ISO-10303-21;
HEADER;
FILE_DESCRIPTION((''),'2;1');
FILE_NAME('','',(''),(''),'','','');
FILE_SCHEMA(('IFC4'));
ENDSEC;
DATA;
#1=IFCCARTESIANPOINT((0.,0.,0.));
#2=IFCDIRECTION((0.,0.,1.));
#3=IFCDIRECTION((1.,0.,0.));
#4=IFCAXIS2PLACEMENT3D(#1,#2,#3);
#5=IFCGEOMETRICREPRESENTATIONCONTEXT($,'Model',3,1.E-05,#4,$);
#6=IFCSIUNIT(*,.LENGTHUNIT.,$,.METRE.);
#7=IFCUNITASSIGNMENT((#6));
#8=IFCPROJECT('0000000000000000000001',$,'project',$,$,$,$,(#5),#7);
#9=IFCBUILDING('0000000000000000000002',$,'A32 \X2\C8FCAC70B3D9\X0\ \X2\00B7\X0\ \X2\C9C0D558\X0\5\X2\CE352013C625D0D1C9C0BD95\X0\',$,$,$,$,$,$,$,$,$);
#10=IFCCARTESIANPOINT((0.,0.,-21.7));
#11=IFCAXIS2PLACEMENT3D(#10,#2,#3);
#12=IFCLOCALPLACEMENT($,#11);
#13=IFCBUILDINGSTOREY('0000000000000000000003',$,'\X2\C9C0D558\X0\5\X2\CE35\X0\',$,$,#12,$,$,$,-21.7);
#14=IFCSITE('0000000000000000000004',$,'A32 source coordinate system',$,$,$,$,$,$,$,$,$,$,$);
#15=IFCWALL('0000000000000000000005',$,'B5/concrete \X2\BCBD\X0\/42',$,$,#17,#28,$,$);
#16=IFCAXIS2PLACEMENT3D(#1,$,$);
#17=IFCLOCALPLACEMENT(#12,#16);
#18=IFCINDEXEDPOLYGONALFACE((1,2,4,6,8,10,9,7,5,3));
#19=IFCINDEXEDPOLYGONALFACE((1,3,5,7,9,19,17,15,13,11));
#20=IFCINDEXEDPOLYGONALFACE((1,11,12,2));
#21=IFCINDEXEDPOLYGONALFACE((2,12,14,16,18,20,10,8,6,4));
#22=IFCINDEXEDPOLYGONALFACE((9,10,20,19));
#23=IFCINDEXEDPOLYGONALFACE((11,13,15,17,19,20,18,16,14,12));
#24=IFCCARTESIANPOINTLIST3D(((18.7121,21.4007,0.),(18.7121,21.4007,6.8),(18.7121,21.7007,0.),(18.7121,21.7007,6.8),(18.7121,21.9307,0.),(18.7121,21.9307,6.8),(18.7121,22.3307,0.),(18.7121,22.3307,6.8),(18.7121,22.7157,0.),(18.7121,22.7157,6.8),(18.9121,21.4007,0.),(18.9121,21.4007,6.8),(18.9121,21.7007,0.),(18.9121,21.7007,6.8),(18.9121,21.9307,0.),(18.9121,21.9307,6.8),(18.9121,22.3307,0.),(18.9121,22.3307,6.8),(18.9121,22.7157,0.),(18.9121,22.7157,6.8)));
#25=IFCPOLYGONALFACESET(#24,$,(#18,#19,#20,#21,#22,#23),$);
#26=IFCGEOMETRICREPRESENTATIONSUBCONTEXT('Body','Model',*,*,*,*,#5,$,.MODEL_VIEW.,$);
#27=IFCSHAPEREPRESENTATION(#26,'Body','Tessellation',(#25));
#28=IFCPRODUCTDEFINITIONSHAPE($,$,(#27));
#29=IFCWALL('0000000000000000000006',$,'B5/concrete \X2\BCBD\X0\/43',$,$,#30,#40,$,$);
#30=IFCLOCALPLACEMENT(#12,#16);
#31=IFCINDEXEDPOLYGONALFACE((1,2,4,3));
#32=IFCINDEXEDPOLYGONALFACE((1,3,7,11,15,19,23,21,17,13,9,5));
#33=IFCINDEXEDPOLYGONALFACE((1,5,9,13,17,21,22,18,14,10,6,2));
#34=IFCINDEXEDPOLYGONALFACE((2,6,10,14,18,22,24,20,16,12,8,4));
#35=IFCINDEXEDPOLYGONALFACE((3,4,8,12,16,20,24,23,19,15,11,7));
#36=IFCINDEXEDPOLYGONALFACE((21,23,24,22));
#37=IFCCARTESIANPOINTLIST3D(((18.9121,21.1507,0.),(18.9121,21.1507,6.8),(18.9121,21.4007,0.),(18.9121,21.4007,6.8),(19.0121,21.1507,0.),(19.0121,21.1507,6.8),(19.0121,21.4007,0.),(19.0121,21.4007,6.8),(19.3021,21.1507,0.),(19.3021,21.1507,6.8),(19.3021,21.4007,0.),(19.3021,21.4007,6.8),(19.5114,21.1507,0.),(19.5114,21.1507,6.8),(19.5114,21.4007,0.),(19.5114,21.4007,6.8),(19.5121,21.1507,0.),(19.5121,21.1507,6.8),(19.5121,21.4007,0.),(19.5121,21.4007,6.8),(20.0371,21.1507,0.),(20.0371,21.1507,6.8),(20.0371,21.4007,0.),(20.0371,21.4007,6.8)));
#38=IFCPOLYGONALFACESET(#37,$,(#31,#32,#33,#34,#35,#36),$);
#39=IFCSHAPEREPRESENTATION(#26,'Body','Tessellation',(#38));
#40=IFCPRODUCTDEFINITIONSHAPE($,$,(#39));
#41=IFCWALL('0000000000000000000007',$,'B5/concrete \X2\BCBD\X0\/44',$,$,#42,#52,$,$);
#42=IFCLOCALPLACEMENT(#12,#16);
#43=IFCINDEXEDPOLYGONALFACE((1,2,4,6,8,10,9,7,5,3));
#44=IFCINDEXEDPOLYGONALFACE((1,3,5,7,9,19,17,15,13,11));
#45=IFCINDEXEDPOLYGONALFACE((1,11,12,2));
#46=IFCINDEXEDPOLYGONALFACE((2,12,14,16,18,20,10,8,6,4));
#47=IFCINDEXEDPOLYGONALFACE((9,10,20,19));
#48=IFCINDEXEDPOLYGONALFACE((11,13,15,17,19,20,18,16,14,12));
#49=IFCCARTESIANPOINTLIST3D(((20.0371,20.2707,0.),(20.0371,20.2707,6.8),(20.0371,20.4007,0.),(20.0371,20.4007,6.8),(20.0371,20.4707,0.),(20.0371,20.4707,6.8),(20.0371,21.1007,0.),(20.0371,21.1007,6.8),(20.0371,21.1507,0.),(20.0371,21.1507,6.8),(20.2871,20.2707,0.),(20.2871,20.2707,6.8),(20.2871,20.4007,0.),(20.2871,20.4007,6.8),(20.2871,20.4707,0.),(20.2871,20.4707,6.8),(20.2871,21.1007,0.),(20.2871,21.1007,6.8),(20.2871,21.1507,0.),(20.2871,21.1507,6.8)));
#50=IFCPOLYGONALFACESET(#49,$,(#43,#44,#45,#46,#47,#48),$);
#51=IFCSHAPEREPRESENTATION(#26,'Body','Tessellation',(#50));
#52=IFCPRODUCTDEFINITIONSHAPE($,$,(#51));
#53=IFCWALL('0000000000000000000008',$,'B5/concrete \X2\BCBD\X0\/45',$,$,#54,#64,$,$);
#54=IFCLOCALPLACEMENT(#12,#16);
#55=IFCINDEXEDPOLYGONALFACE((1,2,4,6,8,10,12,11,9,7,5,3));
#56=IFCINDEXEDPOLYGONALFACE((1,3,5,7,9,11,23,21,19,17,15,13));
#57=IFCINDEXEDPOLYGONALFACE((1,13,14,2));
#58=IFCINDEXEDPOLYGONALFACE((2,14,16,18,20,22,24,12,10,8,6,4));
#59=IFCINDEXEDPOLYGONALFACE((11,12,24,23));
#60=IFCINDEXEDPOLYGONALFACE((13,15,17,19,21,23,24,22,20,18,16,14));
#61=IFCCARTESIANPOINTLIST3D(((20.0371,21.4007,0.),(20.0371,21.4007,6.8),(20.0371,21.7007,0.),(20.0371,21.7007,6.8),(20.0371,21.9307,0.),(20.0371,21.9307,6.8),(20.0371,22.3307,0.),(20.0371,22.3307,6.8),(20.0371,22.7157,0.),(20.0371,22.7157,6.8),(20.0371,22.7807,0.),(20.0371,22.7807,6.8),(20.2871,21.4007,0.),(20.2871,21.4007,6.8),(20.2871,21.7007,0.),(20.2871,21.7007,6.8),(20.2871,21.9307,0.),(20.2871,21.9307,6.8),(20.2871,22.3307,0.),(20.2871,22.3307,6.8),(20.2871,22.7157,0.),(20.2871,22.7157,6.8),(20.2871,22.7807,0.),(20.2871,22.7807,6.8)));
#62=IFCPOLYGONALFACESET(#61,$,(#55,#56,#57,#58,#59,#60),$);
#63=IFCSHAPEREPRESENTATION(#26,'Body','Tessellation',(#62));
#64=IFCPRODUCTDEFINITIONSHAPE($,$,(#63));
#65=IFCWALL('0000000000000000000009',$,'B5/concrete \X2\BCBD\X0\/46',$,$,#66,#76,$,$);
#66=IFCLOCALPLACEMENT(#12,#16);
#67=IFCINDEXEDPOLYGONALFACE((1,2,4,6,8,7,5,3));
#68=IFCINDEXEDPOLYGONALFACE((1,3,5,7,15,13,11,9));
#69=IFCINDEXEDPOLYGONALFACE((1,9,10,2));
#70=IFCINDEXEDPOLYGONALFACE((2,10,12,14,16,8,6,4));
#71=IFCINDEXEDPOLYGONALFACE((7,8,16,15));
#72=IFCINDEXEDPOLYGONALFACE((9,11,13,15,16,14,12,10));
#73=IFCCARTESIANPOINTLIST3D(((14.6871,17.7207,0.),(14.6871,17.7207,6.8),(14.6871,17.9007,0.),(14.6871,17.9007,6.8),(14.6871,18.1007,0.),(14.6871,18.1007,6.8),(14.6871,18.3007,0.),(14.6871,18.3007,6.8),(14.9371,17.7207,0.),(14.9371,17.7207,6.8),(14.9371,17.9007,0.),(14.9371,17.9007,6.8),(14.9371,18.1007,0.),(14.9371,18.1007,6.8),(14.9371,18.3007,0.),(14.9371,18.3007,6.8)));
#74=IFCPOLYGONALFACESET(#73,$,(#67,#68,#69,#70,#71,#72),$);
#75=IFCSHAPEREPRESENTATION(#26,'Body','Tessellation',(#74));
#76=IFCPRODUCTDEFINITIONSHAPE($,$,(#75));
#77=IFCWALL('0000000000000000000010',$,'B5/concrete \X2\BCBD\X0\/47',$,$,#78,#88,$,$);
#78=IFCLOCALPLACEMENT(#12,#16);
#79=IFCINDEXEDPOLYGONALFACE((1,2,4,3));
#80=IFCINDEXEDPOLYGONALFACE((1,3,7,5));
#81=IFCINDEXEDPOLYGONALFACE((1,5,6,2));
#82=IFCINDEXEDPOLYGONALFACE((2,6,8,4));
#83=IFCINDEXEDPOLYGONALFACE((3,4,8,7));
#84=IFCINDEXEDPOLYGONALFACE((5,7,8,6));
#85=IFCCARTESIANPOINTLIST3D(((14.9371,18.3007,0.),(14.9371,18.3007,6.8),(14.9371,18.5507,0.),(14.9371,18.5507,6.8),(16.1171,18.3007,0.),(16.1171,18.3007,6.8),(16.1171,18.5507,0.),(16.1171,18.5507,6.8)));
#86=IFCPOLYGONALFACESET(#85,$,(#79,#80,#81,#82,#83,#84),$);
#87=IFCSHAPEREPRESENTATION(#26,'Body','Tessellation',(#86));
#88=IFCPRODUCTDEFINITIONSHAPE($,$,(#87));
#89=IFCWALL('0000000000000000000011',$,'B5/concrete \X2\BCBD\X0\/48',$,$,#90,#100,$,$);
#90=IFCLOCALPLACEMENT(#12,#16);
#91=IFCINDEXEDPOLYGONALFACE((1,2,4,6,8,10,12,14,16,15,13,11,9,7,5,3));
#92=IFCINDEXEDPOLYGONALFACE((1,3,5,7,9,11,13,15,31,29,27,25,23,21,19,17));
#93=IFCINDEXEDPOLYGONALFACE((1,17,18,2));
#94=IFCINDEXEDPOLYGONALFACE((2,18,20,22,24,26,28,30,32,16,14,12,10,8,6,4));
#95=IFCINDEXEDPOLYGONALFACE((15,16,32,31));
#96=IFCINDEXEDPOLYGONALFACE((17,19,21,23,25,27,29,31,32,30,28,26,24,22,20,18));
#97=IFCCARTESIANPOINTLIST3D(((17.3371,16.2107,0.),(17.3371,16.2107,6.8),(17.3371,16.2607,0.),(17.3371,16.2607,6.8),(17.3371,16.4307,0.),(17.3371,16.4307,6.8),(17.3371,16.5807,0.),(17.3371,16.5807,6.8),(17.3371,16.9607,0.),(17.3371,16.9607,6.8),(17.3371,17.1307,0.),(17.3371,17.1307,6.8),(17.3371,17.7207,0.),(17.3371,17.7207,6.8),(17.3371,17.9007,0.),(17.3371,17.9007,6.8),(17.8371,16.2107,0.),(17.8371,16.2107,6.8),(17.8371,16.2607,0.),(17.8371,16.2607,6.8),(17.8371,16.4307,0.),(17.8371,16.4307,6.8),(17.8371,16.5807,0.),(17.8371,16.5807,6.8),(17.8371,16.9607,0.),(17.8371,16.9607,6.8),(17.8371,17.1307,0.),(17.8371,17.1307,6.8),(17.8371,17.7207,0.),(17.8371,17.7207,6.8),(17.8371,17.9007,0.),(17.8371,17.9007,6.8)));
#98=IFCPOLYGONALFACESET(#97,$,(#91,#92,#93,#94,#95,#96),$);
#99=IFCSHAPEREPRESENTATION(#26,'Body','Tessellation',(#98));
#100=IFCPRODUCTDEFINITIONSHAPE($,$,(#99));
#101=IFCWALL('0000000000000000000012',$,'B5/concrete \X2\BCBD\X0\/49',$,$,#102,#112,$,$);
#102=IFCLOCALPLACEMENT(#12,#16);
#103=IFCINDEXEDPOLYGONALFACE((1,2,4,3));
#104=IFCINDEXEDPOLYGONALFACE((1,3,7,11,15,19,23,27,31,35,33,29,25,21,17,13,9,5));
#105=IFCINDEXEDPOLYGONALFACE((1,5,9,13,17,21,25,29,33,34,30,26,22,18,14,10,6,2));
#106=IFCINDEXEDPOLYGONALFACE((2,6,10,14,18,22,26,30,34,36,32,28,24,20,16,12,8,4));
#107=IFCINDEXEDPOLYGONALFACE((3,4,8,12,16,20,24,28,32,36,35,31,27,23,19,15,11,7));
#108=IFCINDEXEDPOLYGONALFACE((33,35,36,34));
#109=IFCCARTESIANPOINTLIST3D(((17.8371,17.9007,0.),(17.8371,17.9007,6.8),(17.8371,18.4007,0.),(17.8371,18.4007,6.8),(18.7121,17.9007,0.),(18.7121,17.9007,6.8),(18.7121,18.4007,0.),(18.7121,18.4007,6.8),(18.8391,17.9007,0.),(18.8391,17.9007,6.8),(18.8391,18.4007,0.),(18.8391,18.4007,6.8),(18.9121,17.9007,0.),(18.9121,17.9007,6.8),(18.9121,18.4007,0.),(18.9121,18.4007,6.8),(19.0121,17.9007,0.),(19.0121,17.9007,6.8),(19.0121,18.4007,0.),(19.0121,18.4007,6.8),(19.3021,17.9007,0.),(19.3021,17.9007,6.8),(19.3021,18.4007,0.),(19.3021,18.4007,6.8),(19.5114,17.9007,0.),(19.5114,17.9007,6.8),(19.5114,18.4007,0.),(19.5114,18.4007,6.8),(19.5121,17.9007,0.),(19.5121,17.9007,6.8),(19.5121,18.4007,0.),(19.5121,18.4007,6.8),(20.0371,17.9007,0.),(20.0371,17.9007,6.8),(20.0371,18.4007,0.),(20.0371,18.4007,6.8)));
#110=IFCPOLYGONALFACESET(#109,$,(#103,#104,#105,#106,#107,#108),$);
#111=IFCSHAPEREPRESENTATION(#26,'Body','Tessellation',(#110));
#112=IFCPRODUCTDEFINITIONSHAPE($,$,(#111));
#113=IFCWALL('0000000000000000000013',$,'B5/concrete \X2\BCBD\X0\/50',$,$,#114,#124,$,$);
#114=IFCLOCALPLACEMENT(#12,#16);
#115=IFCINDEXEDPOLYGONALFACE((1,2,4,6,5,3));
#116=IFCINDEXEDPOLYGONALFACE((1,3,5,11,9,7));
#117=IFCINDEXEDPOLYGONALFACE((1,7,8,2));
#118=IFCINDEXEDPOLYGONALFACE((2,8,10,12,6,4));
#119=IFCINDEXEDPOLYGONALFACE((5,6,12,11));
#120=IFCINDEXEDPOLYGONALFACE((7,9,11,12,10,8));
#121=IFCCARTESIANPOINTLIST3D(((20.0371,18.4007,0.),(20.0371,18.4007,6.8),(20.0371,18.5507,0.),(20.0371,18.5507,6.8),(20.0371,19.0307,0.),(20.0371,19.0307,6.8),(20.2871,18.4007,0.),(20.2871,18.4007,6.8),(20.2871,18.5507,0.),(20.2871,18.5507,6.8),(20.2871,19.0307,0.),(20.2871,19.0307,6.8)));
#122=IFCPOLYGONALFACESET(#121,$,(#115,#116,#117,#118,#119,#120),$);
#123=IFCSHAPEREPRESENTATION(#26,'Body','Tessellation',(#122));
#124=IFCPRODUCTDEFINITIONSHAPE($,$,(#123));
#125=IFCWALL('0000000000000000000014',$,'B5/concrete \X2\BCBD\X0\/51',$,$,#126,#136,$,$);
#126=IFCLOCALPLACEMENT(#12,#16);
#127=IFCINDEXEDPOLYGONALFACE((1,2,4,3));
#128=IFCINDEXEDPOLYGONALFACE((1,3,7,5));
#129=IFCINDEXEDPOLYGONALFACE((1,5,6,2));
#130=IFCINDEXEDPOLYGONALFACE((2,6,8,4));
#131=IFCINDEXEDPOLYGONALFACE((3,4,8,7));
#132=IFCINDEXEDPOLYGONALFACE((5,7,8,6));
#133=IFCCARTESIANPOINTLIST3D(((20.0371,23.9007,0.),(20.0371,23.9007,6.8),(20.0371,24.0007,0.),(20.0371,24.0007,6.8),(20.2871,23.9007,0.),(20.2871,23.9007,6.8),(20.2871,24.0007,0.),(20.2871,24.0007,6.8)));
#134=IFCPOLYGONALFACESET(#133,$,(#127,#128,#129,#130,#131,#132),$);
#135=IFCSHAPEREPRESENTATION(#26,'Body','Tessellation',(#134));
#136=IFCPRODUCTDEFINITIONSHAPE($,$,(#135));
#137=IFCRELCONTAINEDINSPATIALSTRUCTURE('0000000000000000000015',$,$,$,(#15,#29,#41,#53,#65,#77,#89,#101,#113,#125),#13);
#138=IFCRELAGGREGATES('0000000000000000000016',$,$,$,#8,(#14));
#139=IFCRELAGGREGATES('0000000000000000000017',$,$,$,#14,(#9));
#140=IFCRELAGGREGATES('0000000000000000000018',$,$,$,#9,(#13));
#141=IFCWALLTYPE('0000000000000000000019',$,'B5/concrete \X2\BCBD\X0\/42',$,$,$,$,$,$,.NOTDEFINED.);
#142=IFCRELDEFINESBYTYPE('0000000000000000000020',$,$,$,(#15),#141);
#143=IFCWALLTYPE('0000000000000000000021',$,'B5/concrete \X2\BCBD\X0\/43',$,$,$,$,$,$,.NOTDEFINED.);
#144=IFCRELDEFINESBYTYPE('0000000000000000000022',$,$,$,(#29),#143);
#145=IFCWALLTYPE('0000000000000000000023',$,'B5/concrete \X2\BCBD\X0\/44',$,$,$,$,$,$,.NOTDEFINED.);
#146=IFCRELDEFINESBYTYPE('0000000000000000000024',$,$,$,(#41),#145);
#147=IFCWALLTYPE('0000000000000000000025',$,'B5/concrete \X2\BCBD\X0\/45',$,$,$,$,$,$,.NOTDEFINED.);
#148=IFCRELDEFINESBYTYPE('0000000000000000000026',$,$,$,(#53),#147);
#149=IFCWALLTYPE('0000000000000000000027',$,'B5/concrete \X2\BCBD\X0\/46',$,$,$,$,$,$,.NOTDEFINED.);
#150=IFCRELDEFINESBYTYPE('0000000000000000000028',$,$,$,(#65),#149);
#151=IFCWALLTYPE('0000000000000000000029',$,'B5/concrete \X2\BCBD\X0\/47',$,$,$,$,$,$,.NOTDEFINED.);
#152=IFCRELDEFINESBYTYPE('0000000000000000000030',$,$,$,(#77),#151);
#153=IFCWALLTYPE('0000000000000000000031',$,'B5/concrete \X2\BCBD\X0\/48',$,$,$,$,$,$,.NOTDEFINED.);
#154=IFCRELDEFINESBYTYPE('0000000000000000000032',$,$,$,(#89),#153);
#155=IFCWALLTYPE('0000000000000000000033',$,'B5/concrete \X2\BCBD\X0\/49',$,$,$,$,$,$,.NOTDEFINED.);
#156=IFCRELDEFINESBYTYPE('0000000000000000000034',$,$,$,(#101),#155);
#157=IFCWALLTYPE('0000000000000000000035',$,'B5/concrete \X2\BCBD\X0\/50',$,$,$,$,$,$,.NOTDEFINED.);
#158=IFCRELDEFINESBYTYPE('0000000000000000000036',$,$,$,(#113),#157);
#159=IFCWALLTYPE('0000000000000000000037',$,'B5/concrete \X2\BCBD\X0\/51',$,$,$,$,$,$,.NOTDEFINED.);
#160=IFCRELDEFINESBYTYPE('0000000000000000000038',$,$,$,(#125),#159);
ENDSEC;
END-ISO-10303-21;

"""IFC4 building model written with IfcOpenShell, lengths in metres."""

from ifc_helpers import new_model, si_unit, frame, origin, origin_with_axes, place, context, subcontext, project, spatial, polyline, outline, extrude, source, transform, mapped, type_object, type_shapes, element, save


model = new_model("IFC4")

# Units and contexts
model_context = context("Model", 3, precision=1e-05, world=origin_with_axes())
body_context = subcontext(model_context, "Body", "Model", "MODEL_VIEW")
ifc_project = project(units=[si_unit("LENGTHUNIT", "METRE")], contexts=[model_context])

# Site, building, storey
site = spatial("IfcSite", under=ifc_project, Name="A32 source coordinate system")
building = spatial("IfcBuilding", under=site, Name="A32 주거동 · 지하5층–옥탑지붕")
storey_placement = place(None, frame((0.0, 0.0, -21.7), z_axis=(0.0, 0.0, 1.0), x_axis=(1.0, 0.0, 0.0)))
storey = spatial("IfcBuildingStorey", under=building, at=storey_placement, Name="지하5층", Elevation=-21.7)

# Walls
wall_type_1 = type_object("IfcWallType", Name="B5/concrete 벽/42", PredefinedType="NOTDEFINED")
shared_shape_1 = source(origin(), body_context, "Body", "SweptSolid", [
    extrude(outline(polyline([(18.7121, 22.3307), (18.7121, 22.7157), (18.9121, 22.7157), (18.9121, 22.3307), (18.9121, 21.9307), (18.9121, 21.7007), (18.9121, 21.4007), (18.7121, 21.4007), (18.7121, 21.7007), (18.7121, 21.9307), (18.7121, 22.3307)])), origin(), (0.0, 0.0, 1.0), 6.8),
])
type_shapes(wall_type_1, [shared_shape_1])
wall_1_placement = place(storey_placement, origin_with_axes())
element("IfcWall", 1, at=wall_1_placement, inside=storey, type_object=wall_type_1, Name="B5/concrete 벽/42", context=body_context, shape_type="MappedRepresentation", body=[
    mapped(shared_shape_1, transform((0.0, 0.0, 0.0), scale=1.0)),
])
wall_type_2 = type_object("IfcWallType", Name="B5/concrete 벽/43", PredefinedType="NOTDEFINED")
shared_shape_2 = source(origin(), body_context, "Body", "SweptSolid", [
    extrude(outline(polyline([(19.5114, 21.4007), (19.5121, 21.4007), (20.0371, 21.4007), (20.0371, 21.1507), (19.5121, 21.1507), (19.5114, 21.1507), (19.3021, 21.1507), (19.0121, 21.1507), (18.9121, 21.1507), (18.9121, 21.4007), (19.0121, 21.4007), (19.3021, 21.4007), (19.5114, 21.4007)])), origin(), (0.0, 0.0, 1.0), 6.8),
])
type_shapes(wall_type_2, [shared_shape_2])
wall_2_placement = place(storey_placement, origin_with_axes())
element("IfcWall", 2, at=wall_2_placement, inside=storey, type_object=wall_type_2, Name="B5/concrete 벽/43", context=body_context, shape_type="MappedRepresentation", body=[
    mapped(shared_shape_2, transform((0.0, 0.0, 0.0), scale=1.0)),
])
wall_type_3 = type_object("IfcWallType", Name="B5/concrete 벽/44", PredefinedType="NOTDEFINED")
shared_shape_3 = source(origin(), body_context, "Body", "SweptSolid", [
    extrude(outline(polyline([(20.2871, 20.4707), (20.2871, 20.4007), (20.2871, 20.2707), (20.0371, 20.2707), (20.0371, 20.4007), (20.0371, 20.4707), (20.0371, 21.1007), (20.0371, 21.1507), (20.2871, 21.1507), (20.2871, 21.1007), (20.2871, 20.4707)])), origin(), (0.0, 0.0, 1.0), 6.8),
])
type_shapes(wall_type_3, [shared_shape_3])
wall_3_placement = place(storey_placement, origin_with_axes())
element("IfcWall", 3, at=wall_3_placement, inside=storey, type_object=wall_type_3, Name="B5/concrete 벽/44", context=body_context, shape_type="MappedRepresentation", body=[
    mapped(shared_shape_3, transform((0.0, 0.0, 0.0), scale=1.0)),
])
wall_type_4 = type_object("IfcWallType", Name="B5/concrete 벽/45", PredefinedType="NOTDEFINED")
shared_shape_4 = source(origin(), body_context, "Body", "SweptSolid", [
    extrude(outline(polyline([(20.0371, 22.3307), (20.0371, 22.7157), (20.0371, 22.7807), (20.2871, 22.7807), (20.2871, 22.7157), (20.2871, 22.3307), (20.2871, 21.9307), (20.2871, 21.7007), (20.2871, 21.4007), (20.0371, 21.4007), (20.0371, 21.7007), (20.0371, 21.9307), (20.0371, 22.3307)])), origin(), (0.0, 0.0, 1.0), 6.8),
])
type_shapes(wall_type_4, [shared_shape_4])
wall_4_placement = place(storey_placement, origin_with_axes())
element("IfcWall", 4, at=wall_4_placement, inside=storey, type_object=wall_type_4, Name="B5/concrete 벽/45", context=body_context, shape_type="MappedRepresentation", body=[
    mapped(shared_shape_4, transform((0.0, 0.0, 0.0), scale=1.0)),
])
wall_type_5 = type_object("IfcWallType", Name="B5/concrete 벽/46", PredefinedType="NOTDEFINED")
shared_shape_5 = source(origin(), body_context, "Body", "SweptSolid", [
    extrude(outline(polyline([(14.9371, 17.9007), (14.9371, 17.7207), (14.6871, 17.7207), (14.6871, 17.9007), (14.6871, 18.1007), (14.6871, 18.3007), (14.9371, 18.3007), (14.9371, 18.1007), (14.9371, 17.9007)])), origin(), (0.0, 0.0, 1.0), 6.8),
])
type_shapes(wall_type_5, [shared_shape_5])
wall_5_placement = place(storey_placement, origin_with_axes())
element("IfcWall", 5, at=wall_5_placement, inside=storey, type_object=wall_type_5, Name="B5/concrete 벽/46", context=body_context, shape_type="MappedRepresentation", body=[
    mapped(shared_shape_5, transform((0.0, 0.0, 0.0), scale=1.0)),
])
wall_type_6 = type_object("IfcWallType", Name="B5/concrete 벽/47", PredefinedType="NOTDEFINED")
shared_shape_6 = source(origin(), body_context, "Body", "SweptSolid", [
    extrude(outline(polyline([(16.1171, 18.3007), (14.9371, 18.3007), (14.9371, 18.5507), (16.1171, 18.5507), (16.1171, 18.3007)])), origin(), (0.0, 0.0, 1.0), 6.8),
])
type_shapes(wall_type_6, [shared_shape_6])
wall_6_placement = place(storey_placement, origin_with_axes())
element("IfcWall", 6, at=wall_6_placement, inside=storey, type_object=wall_type_6, Name="B5/concrete 벽/47", context=body_context, shape_type="MappedRepresentation", body=[
    mapped(shared_shape_6, transform((0.0, 0.0, 0.0), scale=1.0)),
])
wall_type_7 = type_object("IfcWallType", Name="B5/concrete 벽/48", PredefinedType="NOTDEFINED")
shared_shape_7 = source(origin(), body_context, "Body", "SweptSolid", [
    extrude(outline(polyline([(17.8371, 17.1307), (17.8371, 16.9607), (17.8371, 16.5807), (17.8371, 16.4307), (17.8371, 16.2607), (17.8371, 16.2107), (17.3371, 16.2107), (17.3371, 16.2607), (17.3371, 16.4307), (17.3371, 16.5807), (17.3371, 16.9607), (17.3371, 17.1307), (17.3371, 17.7207), (17.3371, 17.9007), (17.8371, 17.9007), (17.8371, 17.7207), (17.8371, 17.1307)])), origin(), (0.0, 0.0, 1.0), 6.8),
])
type_shapes(wall_type_7, [shared_shape_7])
wall_7_placement = place(storey_placement, origin_with_axes())
element("IfcWall", 7, at=wall_7_placement, inside=storey, type_object=wall_type_7, Name="B5/concrete 벽/48", context=body_context, shape_type="MappedRepresentation", body=[
    mapped(shared_shape_7, transform((0.0, 0.0, 0.0), scale=1.0)),
])
wall_type_8 = type_object("IfcWallType", Name="B5/concrete 벽/49", PredefinedType="NOTDEFINED")
shared_shape_8 = source(origin(), body_context, "Body", "SweptSolid", [
    extrude(outline(polyline([(18.8391, 18.4007), (18.9121, 18.4007), (19.0121, 18.4007), (19.3021, 18.4007), (19.5114, 18.4007), (19.5121, 18.4007), (20.0371, 18.4007), (20.0371, 17.9007), (19.5121, 17.9007), (19.5114, 17.9007), (19.3021, 17.9007), (19.0121, 17.9007), (18.9121, 17.9007), (18.8391, 17.9007), (18.7121, 17.9007), (17.8371, 17.9007), (17.8371, 18.4007), (18.7121, 18.4007), (18.8391, 18.4007)])), origin(), (0.0, 0.0, 1.0), 6.8),
])
type_shapes(wall_type_8, [shared_shape_8])
wall_8_placement = place(storey_placement, origin_with_axes())
element("IfcWall", 8, at=wall_8_placement, inside=storey, type_object=wall_type_8, Name="B5/concrete 벽/49", context=body_context, shape_type="MappedRepresentation", body=[
    mapped(shared_shape_8, transform((0.0, 0.0, 0.0), scale=1.0)),
])
wall_type_9 = type_object("IfcWallType", Name="B5/concrete 벽/50", PredefinedType="NOTDEFINED")
shared_shape_9 = source(origin(), body_context, "Body", "SweptSolid", [
    extrude(outline(polyline([(20.2871, 19.0307), (20.2871, 18.5507), (20.2871, 18.4007), (20.0371, 18.4007), (20.0371, 18.5507), (20.0371, 19.0307), (20.2871, 19.0307)])), origin(), (0.0, 0.0, 1.0), 6.8),
])
type_shapes(wall_type_9, [shared_shape_9])
wall_9_placement = place(storey_placement, origin_with_axes())
element("IfcWall", 9, at=wall_9_placement, inside=storey, type_object=wall_type_9, Name="B5/concrete 벽/50", context=body_context, shape_type="MappedRepresentation", body=[
    mapped(shared_shape_9, transform((0.0, 0.0, 0.0), scale=1.0)),
])
wall_type_10 = type_object("IfcWallType", Name="B5/concrete 벽/51", PredefinedType="NOTDEFINED")
shared_shape_10 = source(origin(), body_context, "Body", "SweptSolid", [
    extrude(outline(polyline([(20.2871, 23.9007), (20.0371, 23.9007), (20.0371, 24.0007), (20.2871, 24.0007), (20.2871, 23.9007)])), origin(), (0.0, 0.0, 1.0), 6.8),
])
type_shapes(wall_type_10, [shared_shape_10])
wall_10_placement = place(storey_placement, origin_with_axes())
element("IfcWall", 10, at=wall_10_placement, inside=storey, type_object=wall_type_10, Name="B5/concrete 벽/51", context=body_context, shape_type="MappedRepresentation", body=[
    mapped(shared_shape_10, transform((0.0, 0.0, 0.0), scale=1.0)),
])

save(model, "model.ifc")
